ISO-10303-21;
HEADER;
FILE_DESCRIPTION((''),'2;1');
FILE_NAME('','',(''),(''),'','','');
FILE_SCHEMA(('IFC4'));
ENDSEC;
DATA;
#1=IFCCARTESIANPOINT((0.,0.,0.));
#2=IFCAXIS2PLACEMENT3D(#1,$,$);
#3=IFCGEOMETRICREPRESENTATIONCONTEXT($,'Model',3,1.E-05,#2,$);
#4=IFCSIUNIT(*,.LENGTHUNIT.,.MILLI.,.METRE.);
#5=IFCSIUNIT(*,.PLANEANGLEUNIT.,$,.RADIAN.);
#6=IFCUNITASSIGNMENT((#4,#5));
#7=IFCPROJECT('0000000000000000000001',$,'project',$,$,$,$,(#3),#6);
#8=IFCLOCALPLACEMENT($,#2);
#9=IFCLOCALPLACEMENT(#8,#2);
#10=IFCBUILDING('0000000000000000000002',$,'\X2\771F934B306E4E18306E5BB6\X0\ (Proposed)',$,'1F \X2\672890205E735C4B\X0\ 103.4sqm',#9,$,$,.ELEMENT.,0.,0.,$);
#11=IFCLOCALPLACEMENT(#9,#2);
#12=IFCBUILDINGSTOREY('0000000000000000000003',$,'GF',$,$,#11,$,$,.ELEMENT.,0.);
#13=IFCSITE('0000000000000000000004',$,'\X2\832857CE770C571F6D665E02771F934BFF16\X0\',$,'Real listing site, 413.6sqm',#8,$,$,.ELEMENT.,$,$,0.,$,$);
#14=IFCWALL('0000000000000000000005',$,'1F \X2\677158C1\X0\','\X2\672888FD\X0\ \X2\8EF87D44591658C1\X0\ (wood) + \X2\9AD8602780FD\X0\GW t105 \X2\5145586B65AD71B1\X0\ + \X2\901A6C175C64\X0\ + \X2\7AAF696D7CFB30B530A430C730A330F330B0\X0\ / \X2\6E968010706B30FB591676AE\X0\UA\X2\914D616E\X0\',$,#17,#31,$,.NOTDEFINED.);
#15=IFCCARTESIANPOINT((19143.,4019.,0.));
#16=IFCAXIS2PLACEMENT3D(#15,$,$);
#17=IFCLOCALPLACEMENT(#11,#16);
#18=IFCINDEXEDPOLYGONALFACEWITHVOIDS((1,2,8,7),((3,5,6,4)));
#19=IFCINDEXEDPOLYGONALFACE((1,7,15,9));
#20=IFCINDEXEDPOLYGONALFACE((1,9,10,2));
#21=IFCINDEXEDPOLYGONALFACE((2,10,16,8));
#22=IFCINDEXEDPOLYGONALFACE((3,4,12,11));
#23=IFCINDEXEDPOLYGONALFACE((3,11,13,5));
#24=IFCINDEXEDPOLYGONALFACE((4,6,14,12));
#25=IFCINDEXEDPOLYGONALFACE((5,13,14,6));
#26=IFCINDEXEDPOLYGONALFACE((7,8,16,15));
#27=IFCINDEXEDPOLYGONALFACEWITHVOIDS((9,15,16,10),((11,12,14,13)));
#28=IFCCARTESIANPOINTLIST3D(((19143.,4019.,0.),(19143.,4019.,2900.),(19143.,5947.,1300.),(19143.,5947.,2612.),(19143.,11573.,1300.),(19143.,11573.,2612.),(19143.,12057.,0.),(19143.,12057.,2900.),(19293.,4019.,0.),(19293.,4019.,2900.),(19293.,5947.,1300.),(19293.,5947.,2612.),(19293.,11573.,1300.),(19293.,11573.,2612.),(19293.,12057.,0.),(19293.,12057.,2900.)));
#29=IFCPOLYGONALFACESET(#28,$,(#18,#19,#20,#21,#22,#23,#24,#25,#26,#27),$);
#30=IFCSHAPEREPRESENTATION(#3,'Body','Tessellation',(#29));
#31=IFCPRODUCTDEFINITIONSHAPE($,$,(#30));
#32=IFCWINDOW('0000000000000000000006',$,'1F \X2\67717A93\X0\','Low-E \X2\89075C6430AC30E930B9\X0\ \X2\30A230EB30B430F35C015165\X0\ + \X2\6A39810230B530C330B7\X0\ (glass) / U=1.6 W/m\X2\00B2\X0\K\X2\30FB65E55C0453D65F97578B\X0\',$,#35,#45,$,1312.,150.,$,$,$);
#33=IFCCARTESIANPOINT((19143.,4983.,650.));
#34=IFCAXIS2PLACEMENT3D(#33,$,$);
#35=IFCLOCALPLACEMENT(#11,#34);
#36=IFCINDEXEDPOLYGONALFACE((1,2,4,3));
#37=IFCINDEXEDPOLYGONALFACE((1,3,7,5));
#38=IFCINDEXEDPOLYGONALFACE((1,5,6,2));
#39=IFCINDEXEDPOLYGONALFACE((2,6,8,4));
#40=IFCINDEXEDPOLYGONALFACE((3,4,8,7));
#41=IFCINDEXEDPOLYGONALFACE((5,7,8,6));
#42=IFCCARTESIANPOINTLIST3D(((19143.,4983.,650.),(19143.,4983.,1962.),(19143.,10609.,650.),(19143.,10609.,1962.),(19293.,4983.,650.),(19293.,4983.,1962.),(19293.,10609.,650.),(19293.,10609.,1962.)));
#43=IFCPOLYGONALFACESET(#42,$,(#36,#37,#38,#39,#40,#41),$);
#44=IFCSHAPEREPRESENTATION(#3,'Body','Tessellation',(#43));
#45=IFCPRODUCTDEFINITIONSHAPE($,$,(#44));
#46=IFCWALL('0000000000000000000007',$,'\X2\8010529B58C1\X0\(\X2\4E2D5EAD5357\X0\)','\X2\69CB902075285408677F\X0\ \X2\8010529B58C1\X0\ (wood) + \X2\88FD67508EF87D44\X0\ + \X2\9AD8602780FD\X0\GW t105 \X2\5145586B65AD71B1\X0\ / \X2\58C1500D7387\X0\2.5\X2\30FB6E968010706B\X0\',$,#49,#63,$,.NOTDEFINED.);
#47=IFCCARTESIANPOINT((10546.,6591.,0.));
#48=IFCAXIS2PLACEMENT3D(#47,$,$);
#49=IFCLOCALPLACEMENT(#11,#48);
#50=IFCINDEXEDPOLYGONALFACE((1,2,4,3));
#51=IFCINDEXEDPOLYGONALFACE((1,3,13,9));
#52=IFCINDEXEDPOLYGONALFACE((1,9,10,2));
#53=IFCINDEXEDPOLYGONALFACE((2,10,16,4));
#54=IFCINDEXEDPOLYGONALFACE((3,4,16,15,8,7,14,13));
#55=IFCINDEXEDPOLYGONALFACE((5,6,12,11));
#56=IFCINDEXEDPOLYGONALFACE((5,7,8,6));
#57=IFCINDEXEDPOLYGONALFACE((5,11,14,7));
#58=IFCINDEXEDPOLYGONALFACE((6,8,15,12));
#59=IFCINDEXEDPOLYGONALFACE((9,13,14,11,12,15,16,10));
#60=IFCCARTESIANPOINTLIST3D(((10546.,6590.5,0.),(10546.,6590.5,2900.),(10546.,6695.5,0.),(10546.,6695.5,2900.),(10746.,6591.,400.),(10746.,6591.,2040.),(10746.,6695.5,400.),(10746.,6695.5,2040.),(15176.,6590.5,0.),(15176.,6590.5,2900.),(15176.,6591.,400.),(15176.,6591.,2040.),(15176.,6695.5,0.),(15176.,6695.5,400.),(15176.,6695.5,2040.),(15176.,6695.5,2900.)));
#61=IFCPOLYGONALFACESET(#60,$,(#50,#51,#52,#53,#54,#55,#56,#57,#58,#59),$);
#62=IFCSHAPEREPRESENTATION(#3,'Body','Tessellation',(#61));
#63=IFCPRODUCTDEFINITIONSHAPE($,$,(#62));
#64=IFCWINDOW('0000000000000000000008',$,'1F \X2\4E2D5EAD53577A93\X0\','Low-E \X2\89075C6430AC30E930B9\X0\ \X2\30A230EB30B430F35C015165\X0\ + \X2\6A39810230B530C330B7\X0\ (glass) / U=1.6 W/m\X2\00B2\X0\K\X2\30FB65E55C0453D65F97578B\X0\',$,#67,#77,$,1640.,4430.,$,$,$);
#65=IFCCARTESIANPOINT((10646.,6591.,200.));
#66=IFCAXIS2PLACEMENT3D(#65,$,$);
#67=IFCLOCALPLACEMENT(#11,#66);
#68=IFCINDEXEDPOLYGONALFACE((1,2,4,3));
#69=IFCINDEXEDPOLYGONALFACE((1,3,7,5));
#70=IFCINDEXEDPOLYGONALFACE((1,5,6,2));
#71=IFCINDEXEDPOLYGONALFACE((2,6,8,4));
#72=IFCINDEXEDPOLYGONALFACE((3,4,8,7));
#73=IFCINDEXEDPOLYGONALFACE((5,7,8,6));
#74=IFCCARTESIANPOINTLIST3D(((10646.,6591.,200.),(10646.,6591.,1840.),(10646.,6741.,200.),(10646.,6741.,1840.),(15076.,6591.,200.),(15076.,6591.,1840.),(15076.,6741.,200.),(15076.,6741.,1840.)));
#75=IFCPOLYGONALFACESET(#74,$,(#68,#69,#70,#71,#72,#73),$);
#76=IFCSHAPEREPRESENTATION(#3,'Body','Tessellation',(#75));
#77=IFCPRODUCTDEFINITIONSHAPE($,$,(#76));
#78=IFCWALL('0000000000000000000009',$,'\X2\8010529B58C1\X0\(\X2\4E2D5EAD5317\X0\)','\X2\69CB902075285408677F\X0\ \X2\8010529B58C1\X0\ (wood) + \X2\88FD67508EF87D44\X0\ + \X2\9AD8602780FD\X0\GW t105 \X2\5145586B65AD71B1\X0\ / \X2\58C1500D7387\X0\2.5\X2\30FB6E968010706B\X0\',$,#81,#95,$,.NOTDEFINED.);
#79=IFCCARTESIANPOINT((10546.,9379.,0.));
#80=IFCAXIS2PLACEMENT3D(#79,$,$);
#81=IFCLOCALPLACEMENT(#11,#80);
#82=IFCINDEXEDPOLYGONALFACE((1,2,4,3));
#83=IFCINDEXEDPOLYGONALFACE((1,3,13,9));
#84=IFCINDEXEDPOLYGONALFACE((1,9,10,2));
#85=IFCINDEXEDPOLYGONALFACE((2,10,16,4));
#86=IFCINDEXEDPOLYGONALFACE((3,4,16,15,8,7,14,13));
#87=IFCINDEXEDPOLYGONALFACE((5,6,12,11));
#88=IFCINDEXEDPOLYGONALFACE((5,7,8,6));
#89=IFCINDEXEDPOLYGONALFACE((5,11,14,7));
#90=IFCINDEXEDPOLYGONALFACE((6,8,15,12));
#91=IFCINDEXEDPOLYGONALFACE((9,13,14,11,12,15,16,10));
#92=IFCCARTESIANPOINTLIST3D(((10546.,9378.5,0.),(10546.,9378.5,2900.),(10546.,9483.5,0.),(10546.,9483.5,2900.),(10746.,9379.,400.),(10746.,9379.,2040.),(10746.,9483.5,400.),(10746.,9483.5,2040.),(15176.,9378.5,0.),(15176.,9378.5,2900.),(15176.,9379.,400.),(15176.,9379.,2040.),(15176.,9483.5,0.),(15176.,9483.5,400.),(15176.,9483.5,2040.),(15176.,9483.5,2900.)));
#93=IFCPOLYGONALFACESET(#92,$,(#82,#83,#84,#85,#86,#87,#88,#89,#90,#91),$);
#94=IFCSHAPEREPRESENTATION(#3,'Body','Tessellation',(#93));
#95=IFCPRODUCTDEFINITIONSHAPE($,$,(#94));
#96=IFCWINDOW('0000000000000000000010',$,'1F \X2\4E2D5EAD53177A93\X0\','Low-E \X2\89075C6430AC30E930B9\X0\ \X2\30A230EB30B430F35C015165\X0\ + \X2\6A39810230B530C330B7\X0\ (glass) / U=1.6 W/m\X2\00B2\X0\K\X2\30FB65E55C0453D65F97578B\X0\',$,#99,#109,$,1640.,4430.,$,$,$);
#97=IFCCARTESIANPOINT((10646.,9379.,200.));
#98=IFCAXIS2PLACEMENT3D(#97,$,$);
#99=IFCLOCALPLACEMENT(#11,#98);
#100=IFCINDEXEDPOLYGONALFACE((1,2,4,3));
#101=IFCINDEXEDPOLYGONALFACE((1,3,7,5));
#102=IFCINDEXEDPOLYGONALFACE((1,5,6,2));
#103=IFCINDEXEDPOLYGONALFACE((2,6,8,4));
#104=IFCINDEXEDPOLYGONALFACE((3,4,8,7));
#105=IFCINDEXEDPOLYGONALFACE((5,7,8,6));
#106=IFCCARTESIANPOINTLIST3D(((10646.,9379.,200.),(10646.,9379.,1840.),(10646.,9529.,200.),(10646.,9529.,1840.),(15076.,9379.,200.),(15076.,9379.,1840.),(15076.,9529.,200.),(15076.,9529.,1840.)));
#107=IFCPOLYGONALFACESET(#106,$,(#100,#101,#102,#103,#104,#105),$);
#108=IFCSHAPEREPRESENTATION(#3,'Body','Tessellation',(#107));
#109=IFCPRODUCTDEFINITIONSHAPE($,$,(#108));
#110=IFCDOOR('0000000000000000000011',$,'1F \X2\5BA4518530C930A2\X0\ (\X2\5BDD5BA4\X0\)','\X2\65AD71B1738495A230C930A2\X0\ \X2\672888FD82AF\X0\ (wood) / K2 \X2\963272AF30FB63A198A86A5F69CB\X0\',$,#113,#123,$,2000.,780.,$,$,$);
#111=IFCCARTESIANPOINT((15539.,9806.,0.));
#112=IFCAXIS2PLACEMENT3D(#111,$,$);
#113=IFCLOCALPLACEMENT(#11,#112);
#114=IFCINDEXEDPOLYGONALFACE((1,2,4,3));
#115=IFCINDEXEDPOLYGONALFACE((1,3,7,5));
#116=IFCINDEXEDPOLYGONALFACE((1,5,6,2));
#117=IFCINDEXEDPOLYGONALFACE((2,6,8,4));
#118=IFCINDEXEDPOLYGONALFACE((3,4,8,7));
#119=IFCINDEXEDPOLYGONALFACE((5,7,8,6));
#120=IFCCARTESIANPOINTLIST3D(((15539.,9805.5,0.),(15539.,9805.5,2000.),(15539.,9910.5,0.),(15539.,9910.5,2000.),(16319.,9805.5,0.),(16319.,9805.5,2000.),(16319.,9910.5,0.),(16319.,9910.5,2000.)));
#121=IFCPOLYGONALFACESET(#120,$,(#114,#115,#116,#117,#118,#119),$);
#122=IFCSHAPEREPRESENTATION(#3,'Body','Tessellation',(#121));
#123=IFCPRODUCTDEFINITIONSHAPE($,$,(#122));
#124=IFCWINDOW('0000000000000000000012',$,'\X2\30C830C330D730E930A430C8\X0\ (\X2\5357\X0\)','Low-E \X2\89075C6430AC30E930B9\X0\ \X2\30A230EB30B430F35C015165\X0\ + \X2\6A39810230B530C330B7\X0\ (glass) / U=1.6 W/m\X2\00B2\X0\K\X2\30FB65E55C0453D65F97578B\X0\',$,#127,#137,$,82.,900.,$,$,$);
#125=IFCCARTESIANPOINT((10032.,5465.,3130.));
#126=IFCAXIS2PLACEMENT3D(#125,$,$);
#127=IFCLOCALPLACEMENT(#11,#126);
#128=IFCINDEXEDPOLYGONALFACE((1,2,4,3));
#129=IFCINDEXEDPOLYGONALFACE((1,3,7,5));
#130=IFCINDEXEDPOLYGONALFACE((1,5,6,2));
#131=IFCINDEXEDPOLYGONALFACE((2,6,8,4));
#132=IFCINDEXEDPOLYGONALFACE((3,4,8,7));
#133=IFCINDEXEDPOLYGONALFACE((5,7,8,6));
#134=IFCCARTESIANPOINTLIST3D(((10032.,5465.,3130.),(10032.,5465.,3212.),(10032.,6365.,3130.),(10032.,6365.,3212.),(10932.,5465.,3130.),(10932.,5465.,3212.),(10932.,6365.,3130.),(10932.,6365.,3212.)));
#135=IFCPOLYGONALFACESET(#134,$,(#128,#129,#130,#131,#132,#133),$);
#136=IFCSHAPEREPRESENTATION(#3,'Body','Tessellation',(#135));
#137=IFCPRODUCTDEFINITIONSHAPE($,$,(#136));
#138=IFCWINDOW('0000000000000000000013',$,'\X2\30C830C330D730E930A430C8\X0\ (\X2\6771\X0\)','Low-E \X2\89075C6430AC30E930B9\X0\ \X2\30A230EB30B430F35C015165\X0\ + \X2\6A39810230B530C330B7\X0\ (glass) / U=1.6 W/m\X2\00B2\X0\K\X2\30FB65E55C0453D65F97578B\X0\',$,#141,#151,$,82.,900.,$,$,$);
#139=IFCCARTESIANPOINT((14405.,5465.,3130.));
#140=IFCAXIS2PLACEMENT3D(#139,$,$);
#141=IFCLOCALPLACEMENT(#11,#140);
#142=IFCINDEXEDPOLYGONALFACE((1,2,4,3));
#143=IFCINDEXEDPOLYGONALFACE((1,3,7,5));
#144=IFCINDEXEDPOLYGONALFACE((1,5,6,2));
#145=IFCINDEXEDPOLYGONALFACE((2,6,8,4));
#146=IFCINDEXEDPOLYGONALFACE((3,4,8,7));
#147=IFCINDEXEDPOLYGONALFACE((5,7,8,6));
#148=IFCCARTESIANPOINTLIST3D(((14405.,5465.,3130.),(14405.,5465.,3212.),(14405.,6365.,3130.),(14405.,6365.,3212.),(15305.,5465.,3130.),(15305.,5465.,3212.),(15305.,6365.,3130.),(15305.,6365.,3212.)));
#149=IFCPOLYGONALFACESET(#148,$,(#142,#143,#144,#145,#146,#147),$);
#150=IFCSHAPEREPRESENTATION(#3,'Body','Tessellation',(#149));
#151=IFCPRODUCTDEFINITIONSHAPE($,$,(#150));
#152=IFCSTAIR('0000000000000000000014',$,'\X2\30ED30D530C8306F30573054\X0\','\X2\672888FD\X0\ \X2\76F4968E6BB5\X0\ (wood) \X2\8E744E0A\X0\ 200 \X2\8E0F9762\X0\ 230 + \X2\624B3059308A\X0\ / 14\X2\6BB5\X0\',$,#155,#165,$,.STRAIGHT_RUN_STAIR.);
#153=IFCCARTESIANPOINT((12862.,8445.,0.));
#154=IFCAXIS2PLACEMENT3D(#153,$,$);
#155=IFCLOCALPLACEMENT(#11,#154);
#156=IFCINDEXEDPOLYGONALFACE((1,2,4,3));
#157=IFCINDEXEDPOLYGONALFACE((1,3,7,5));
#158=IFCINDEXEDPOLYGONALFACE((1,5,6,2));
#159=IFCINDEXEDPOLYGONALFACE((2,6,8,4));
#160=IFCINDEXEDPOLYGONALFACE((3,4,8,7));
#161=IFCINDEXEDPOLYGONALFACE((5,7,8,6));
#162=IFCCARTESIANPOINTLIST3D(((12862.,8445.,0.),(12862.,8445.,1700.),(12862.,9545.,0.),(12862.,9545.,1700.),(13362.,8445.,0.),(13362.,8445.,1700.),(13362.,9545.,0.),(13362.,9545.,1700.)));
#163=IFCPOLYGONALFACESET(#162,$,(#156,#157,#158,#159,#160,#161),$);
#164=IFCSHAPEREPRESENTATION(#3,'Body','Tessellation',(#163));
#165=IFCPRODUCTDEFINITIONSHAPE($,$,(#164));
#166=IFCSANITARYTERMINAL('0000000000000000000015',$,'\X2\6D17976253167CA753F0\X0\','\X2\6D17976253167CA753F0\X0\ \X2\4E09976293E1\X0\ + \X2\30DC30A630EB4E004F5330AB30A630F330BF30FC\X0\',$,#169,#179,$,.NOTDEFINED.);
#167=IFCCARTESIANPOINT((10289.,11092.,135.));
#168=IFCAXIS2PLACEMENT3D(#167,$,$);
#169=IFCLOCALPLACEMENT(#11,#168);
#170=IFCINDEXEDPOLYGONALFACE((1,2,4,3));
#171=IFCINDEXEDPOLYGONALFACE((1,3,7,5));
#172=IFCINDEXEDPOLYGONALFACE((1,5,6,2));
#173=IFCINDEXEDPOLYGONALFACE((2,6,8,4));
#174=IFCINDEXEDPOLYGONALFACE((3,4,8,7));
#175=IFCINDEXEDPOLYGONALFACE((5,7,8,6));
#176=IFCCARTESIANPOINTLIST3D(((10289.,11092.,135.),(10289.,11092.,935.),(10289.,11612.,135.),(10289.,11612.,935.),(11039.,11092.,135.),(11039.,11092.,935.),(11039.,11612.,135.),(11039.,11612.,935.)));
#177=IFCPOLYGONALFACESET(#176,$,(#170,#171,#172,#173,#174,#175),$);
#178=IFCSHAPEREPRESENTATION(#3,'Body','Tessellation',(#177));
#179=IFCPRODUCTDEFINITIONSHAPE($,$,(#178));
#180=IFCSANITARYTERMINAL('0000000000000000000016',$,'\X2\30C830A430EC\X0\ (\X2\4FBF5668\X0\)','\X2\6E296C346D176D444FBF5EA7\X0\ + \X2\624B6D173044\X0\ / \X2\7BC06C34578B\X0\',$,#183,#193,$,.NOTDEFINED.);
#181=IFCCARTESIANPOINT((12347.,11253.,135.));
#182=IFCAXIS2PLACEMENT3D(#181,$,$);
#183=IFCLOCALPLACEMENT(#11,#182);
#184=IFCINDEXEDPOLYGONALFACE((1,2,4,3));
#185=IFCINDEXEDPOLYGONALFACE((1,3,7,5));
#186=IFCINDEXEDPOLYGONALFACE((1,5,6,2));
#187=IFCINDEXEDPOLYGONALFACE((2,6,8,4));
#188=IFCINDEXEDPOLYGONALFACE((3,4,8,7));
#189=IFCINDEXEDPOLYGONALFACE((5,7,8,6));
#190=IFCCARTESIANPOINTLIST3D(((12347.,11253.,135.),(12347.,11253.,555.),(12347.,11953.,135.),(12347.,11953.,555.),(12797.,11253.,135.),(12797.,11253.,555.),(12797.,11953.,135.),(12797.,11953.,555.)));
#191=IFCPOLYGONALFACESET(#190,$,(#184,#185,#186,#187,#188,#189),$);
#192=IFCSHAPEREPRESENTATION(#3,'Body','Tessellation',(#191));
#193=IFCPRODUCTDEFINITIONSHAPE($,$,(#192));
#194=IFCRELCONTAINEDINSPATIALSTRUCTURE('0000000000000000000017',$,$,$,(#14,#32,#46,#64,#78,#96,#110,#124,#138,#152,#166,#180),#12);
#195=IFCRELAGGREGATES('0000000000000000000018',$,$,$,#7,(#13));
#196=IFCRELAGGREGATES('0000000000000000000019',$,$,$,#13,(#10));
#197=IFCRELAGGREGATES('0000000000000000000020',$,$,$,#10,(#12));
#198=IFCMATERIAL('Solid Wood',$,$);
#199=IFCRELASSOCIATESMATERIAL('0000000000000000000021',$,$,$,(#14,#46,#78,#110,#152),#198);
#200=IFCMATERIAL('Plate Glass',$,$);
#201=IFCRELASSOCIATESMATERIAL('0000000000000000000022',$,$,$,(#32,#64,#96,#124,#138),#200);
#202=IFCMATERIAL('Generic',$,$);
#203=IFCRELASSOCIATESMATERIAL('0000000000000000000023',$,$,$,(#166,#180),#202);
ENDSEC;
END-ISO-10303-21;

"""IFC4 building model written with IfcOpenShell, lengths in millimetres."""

from ifc_helpers import new_model, si_unit, frame, frame_2d, origin, place, context, project, spatial, rectangle, extrude, material, element, fill, save


model = new_model("IFC4")

# Units and contexts
model_context = context("Model", 3, precision=1e-05, world=origin())
ifc_project = project(units=[si_unit("LENGTHUNIT", "METRE", prefix="MILLI"), si_unit("PLANEANGLEUNIT", "RADIAN")], contexts=[model_context])

# Site, building, storey
site_placement = place(None, origin())
site = spatial("IfcSite", under=ifc_project, at=site_placement, Name="茨城県土浦市真鍋６", ObjectType="Real listing site, 413.6sqm", CompositionType="ELEMENT", RefElevation=0.0)
building_placement = place(site_placement, origin())
building = spatial("IfcBuilding", under=site, at=building_placement, Name="真鍋の丘の家 (Proposed)", ObjectType="1F 木造平屋 103.4sqm", CompositionType="ELEMENT", ElevationOfRefHeight=0.0, ElevationOfTerrain=0.0)
storey_placement = place(building_placement, origin())
storey = spatial("IfcBuildingStorey", under=building, at=storey_placement, Name="GF", CompositionType="ELEMENT", Elevation=0.0)

# Shared definitions
ifc_material_1 = material(Name="Solid Wood")

# Walls, openings, windows
wall_1_placement = place(storey_placement, frame((19143.0, 4019.0, 0.0)))
wall_1 = element("IfcWall", 1, at=wall_1_placement, inside=storey, material=ifc_material_1, Name="1F 東壁", Description="木製 軸組外壁 (wood) + 高性能GW t105 充填断熱 + 通気層 + 窯業系サイディング / 準耐火・外皮UA配慮", PredefinedType="NOTDEFINED", context=model_context, shape_type="SweptSolid", body=[
    extrude(rectangle(XDim=150.0, YDim=8038.0, at=frame_2d((75.0, 4019.0))), frame((19143.0, 4019.0, 0.0)), (0.0, 0.0, 1.0), 2900.0),
])
opening_1_placement = place(storey_placement, frame((19143.0, 4983.0, 650.0)))
opening_1 = element("IfcOpeningElement", 2, at=opening_1_placement, cuts=wall_1, PredefinedType="NOTDEFINED", context=model_context, shape_type="SweptSolid", body=[
    extrude(rectangle(XDim=150.0, YDim=5626.0, at=frame_2d((75.0, 2813.0))), frame((19143.0, 4983.0, 650.0)), (0.0, 0.0, 1.0), 1312.0),
])
ifc_material_2 = material(Name="Plate Glass")
window_1_placement = place(storey_placement, frame((19143.0, 4983.0, 650.0)))
window_1 = element("IfcWindow", 3, at=window_1_placement, inside=storey, material=ifc_material_2, Name="1F 東窓", Description="Low-E 複層ガラス アルゴン封入 + 樹脂サッシ (glass) / U=1.6 W/m²K・日射取得型", OverallHeight=1312.0, OverallWidth=150.0, context=model_context, shape_type="SweptSolid", body=[
    extrude(rectangle(XDim=150.0, YDim=5626.0, at=frame_2d((75.0, 2813.0))), frame((19143.0, 4983.0, 650.0)), (0.0, 0.0, 1.0), 1312.0),
])
fill(opening_1, window_1)
wall_2_placement = place(storey_placement, frame((10546.0, 6591.0, 0.0)))
wall_2 = element("IfcWall", 4, at=wall_2_placement, inside=storey, material=ifc_material_1, Name="耐力壁(中庭南)", Description="構造用合板 耐力壁 (wood) + 製材軸組 + 高性能GW t105 充填断熱 / 壁倍率2.5・準耐火", PredefinedType="NOTDEFINED", context=model_context, shape_type="SweptSolid", body=[
    extrude(rectangle(XDim=4630.0, YDim=105.0, at=frame_2d((2315.0, 52.0))), frame((10546.0, 6591.0, 0.0)), (0.0, 0.0, 1.0), 2900.0),
])
opening_2_placement = place(storey_placement, frame((10646.0, 6591.0, 200.0)))
opening_2 = element("IfcOpeningElement", 5, at=opening_2_placement, cuts=wall_2, PredefinedType="NOTDEFINED", context=model_context, shape_type="SweptSolid", body=[
    extrude(rectangle(XDim=4430.0, YDim=150.0, at=frame_2d((2215.0, 75.0))), frame((10646.0, 6591.0, 200.0)), (0.0, 0.0, 1.0), 1640.0),
])
window_2_placement = place(storey_placement, frame((10646.0, 6591.0, 200.0)))
window_2 = element("IfcWindow", 6, at=window_2_placement, inside=storey, material=ifc_material_2, Name="1F 中庭南窓", Description="Low-E 複層ガラス アルゴン封入 + 樹脂サッシ (glass) / U=1.6 W/m²K・日射取得型", OverallHeight=1640.0, OverallWidth=4430.0, context=model_context, shape_type="SweptSolid", body=[
    extrude(rectangle(XDim=4430.0, YDim=150.0, at=frame_2d((2215.0, 75.0))), frame((10646.0, 6591.0, 200.0)), (0.0, 0.0, 1.0), 1640.0),
])
fill(opening_2, window_2)
wall_3_placement = place(storey_placement, frame((10546.0, 9379.0, 0.0)))
wall_3 = element("IfcWall", 7, at=wall_3_placement, inside=storey, material=ifc_material_1, Name="耐力壁(中庭北)", Description="構造用合板 耐力壁 (wood) + 製材軸組 + 高性能GW t105 充填断熱 / 壁倍率2.5・準耐火", PredefinedType="NOTDEFINED", context=model_context, shape_type="SweptSolid", body=[
    extrude(rectangle(XDim=4630.0, YDim=105.0, at=frame_2d((2315.0, 52.0))), frame((10546.0, 9379.0, 0.0)), (0.0, 0.0, 1.0), 2900.0),
])
opening_3_placement = place(storey_placement, frame((10646.0, 9379.0, 200.0)))
opening_3 = element("IfcOpeningElement", 8, at=opening_3_placement, cuts=wall_3, PredefinedType="NOTDEFINED", context=model_context, shape_type="SweptSolid", body=[
    extrude(rectangle(XDim=4430.0, YDim=150.0, at=frame_2d((2215.0, 75.0))), frame((10646.0, 9379.0, 200.0)), (0.0, 0.0, 1.0), 1640.0),
])
window_3_placement = place(storey_placement, frame((10646.0, 9379.0, 200.0)))
window_3 = element("IfcWindow", 9, at=window_3_placement, inside=storey, material=ifc_material_2, Name="1F 中庭北窓", Description="Low-E 複層ガラス アルゴン封入 + 樹脂サッシ (glass) / U=1.6 W/m²K・日射取得型", OverallHeight=1640.0, OverallWidth=4430.0, context=model_context, shape_type="SweptSolid", body=[
    extrude(rectangle(XDim=4430.0, YDim=150.0, at=frame_2d((2215.0, 75.0))), frame((10646.0, 9379.0, 200.0)), (0.0, 0.0, 1.0), 1640.0),
])
fill(opening_3, window_3)

# Door
door_placement = place(storey_placement, frame((15539.0, 9806.0, 0.0)))
element("IfcDoor", 10, at=door_placement, inside=storey, material=ifc_material_1, Name="1F 室内ドア (寝室)", Description="断熱玄関ドア 木製芯 (wood) / K2 防犯・採風機構", OverallHeight=2000.0, OverallWidth=780.0, context=model_context, shape_type="SweptSolid", body=[
    extrude(rectangle(XDim=780.0, YDim=105.0, at=frame_2d((390.0, 52.0))), frame((15539.0, 9806.0, 0.0)), (0.0, 0.0, 1.0), 2000.0),
])

# Windows
window_4_placement = place(storey_placement, frame((10032.0, 5465.0, 3130.0)))
element("IfcWindow", 11, at=window_4_placement, inside=storey, material=ifc_material_2, Name="トップライト (南)", Description="Low-E 複層ガラス アルゴン封入 + 樹脂サッシ (glass) / U=1.6 W/m²K・日射取得型", OverallHeight=82.0, OverallWidth=900.0, context=model_context, shape_type="SweptSolid", body=[
    extrude(rectangle(XDim=900.0, YDim=900.0, at=frame_2d((450.0, 450.0))), frame((10032.0, 5465.0, 3130.0)), (0.0, 0.0, 1.0), 82.0),
])
window_5_placement = place(storey_placement, frame((14405.0, 5465.0, 3130.0)))
element("IfcWindow", 12, at=window_5_placement, inside=storey, material=ifc_material_2, Name="トップライト (東)", Description="Low-E 複層ガラス アルゴン封入 + 樹脂サッシ (glass) / U=1.6 W/m²K・日射取得型", OverallHeight=82.0, OverallWidth=900.0, context=model_context, shape_type="SweptSolid", body=[
    extrude(rectangle(XDim=900.0, YDim=900.0, at=frame_2d((450.0, 450.0))), frame((14405.0, 5465.0, 3130.0)), (0.0, 0.0, 1.0), 82.0),
])

# Stair
stair_placement = place(storey_placement, frame((12862.0, 8445.0, 0.0)))
element("IfcStair", 13, at=stair_placement, inside=storey, material=ifc_material_1, Name="ロフトはしご", Description="木製 直階段 (wood) 蹴上 200 踏面 230 + 手すり / 14段", PredefinedType="STRAIGHT_RUN_STAIR", context=model_context, shape_type="SweptSolid", body=[
    extrude(rectangle(XDim=500.0, YDim=1100.0, at=frame_2d((250.0, 550.0))), frame((12862.0, 8445.0, 0.0)), (0.0, 0.0, 1.0), 1700.0),
])

# Shared definitions
ifc_material_3 = material(Name="Generic")

# Sanitary terminals
sanitary_terminal_1_placement = place(storey_placement, frame((10289.0, 11092.0, 135.0)))
element("IfcSanitaryTerminal", 14, at=sanitary_terminal_1_placement, inside=storey, material=ifc_material_3, Name="洗面化粧台", Description="洗面化粧台 三面鏡 + ボウル一体カウンター", PredefinedType="NOTDEFINED", context=model_context, shape_type="SweptSolid", body=[
    extrude(rectangle(XDim=750.0, YDim=520.0, at=frame_2d((375.0, 260.0))), frame((10289.0, 11092.0, 135.0)), (0.0, 0.0, 1.0), 800.0),
])
sanitary_terminal_2_placement = place(storey_placement, frame((12347.0, 11253.0, 135.0)))
element("IfcSanitaryTerminal", 15, at=sanitary_terminal_2_placement, inside=storey, material=ifc_material_3, Name="トイレ (便器)", Description="温水洗浄便座 + 手洗い / 節水型", PredefinedType="NOTDEFINED", context=model_context, shape_type="SweptSolid", body=[
    extrude(rectangle(XDim=450.0, YDim=700.0, at=frame_2d((225.0, 350.0))), frame((12347.0, 11253.0, 135.0)), (0.0, 0.0, 1.0), 420.0),
])

save(model, "model.ifc")
